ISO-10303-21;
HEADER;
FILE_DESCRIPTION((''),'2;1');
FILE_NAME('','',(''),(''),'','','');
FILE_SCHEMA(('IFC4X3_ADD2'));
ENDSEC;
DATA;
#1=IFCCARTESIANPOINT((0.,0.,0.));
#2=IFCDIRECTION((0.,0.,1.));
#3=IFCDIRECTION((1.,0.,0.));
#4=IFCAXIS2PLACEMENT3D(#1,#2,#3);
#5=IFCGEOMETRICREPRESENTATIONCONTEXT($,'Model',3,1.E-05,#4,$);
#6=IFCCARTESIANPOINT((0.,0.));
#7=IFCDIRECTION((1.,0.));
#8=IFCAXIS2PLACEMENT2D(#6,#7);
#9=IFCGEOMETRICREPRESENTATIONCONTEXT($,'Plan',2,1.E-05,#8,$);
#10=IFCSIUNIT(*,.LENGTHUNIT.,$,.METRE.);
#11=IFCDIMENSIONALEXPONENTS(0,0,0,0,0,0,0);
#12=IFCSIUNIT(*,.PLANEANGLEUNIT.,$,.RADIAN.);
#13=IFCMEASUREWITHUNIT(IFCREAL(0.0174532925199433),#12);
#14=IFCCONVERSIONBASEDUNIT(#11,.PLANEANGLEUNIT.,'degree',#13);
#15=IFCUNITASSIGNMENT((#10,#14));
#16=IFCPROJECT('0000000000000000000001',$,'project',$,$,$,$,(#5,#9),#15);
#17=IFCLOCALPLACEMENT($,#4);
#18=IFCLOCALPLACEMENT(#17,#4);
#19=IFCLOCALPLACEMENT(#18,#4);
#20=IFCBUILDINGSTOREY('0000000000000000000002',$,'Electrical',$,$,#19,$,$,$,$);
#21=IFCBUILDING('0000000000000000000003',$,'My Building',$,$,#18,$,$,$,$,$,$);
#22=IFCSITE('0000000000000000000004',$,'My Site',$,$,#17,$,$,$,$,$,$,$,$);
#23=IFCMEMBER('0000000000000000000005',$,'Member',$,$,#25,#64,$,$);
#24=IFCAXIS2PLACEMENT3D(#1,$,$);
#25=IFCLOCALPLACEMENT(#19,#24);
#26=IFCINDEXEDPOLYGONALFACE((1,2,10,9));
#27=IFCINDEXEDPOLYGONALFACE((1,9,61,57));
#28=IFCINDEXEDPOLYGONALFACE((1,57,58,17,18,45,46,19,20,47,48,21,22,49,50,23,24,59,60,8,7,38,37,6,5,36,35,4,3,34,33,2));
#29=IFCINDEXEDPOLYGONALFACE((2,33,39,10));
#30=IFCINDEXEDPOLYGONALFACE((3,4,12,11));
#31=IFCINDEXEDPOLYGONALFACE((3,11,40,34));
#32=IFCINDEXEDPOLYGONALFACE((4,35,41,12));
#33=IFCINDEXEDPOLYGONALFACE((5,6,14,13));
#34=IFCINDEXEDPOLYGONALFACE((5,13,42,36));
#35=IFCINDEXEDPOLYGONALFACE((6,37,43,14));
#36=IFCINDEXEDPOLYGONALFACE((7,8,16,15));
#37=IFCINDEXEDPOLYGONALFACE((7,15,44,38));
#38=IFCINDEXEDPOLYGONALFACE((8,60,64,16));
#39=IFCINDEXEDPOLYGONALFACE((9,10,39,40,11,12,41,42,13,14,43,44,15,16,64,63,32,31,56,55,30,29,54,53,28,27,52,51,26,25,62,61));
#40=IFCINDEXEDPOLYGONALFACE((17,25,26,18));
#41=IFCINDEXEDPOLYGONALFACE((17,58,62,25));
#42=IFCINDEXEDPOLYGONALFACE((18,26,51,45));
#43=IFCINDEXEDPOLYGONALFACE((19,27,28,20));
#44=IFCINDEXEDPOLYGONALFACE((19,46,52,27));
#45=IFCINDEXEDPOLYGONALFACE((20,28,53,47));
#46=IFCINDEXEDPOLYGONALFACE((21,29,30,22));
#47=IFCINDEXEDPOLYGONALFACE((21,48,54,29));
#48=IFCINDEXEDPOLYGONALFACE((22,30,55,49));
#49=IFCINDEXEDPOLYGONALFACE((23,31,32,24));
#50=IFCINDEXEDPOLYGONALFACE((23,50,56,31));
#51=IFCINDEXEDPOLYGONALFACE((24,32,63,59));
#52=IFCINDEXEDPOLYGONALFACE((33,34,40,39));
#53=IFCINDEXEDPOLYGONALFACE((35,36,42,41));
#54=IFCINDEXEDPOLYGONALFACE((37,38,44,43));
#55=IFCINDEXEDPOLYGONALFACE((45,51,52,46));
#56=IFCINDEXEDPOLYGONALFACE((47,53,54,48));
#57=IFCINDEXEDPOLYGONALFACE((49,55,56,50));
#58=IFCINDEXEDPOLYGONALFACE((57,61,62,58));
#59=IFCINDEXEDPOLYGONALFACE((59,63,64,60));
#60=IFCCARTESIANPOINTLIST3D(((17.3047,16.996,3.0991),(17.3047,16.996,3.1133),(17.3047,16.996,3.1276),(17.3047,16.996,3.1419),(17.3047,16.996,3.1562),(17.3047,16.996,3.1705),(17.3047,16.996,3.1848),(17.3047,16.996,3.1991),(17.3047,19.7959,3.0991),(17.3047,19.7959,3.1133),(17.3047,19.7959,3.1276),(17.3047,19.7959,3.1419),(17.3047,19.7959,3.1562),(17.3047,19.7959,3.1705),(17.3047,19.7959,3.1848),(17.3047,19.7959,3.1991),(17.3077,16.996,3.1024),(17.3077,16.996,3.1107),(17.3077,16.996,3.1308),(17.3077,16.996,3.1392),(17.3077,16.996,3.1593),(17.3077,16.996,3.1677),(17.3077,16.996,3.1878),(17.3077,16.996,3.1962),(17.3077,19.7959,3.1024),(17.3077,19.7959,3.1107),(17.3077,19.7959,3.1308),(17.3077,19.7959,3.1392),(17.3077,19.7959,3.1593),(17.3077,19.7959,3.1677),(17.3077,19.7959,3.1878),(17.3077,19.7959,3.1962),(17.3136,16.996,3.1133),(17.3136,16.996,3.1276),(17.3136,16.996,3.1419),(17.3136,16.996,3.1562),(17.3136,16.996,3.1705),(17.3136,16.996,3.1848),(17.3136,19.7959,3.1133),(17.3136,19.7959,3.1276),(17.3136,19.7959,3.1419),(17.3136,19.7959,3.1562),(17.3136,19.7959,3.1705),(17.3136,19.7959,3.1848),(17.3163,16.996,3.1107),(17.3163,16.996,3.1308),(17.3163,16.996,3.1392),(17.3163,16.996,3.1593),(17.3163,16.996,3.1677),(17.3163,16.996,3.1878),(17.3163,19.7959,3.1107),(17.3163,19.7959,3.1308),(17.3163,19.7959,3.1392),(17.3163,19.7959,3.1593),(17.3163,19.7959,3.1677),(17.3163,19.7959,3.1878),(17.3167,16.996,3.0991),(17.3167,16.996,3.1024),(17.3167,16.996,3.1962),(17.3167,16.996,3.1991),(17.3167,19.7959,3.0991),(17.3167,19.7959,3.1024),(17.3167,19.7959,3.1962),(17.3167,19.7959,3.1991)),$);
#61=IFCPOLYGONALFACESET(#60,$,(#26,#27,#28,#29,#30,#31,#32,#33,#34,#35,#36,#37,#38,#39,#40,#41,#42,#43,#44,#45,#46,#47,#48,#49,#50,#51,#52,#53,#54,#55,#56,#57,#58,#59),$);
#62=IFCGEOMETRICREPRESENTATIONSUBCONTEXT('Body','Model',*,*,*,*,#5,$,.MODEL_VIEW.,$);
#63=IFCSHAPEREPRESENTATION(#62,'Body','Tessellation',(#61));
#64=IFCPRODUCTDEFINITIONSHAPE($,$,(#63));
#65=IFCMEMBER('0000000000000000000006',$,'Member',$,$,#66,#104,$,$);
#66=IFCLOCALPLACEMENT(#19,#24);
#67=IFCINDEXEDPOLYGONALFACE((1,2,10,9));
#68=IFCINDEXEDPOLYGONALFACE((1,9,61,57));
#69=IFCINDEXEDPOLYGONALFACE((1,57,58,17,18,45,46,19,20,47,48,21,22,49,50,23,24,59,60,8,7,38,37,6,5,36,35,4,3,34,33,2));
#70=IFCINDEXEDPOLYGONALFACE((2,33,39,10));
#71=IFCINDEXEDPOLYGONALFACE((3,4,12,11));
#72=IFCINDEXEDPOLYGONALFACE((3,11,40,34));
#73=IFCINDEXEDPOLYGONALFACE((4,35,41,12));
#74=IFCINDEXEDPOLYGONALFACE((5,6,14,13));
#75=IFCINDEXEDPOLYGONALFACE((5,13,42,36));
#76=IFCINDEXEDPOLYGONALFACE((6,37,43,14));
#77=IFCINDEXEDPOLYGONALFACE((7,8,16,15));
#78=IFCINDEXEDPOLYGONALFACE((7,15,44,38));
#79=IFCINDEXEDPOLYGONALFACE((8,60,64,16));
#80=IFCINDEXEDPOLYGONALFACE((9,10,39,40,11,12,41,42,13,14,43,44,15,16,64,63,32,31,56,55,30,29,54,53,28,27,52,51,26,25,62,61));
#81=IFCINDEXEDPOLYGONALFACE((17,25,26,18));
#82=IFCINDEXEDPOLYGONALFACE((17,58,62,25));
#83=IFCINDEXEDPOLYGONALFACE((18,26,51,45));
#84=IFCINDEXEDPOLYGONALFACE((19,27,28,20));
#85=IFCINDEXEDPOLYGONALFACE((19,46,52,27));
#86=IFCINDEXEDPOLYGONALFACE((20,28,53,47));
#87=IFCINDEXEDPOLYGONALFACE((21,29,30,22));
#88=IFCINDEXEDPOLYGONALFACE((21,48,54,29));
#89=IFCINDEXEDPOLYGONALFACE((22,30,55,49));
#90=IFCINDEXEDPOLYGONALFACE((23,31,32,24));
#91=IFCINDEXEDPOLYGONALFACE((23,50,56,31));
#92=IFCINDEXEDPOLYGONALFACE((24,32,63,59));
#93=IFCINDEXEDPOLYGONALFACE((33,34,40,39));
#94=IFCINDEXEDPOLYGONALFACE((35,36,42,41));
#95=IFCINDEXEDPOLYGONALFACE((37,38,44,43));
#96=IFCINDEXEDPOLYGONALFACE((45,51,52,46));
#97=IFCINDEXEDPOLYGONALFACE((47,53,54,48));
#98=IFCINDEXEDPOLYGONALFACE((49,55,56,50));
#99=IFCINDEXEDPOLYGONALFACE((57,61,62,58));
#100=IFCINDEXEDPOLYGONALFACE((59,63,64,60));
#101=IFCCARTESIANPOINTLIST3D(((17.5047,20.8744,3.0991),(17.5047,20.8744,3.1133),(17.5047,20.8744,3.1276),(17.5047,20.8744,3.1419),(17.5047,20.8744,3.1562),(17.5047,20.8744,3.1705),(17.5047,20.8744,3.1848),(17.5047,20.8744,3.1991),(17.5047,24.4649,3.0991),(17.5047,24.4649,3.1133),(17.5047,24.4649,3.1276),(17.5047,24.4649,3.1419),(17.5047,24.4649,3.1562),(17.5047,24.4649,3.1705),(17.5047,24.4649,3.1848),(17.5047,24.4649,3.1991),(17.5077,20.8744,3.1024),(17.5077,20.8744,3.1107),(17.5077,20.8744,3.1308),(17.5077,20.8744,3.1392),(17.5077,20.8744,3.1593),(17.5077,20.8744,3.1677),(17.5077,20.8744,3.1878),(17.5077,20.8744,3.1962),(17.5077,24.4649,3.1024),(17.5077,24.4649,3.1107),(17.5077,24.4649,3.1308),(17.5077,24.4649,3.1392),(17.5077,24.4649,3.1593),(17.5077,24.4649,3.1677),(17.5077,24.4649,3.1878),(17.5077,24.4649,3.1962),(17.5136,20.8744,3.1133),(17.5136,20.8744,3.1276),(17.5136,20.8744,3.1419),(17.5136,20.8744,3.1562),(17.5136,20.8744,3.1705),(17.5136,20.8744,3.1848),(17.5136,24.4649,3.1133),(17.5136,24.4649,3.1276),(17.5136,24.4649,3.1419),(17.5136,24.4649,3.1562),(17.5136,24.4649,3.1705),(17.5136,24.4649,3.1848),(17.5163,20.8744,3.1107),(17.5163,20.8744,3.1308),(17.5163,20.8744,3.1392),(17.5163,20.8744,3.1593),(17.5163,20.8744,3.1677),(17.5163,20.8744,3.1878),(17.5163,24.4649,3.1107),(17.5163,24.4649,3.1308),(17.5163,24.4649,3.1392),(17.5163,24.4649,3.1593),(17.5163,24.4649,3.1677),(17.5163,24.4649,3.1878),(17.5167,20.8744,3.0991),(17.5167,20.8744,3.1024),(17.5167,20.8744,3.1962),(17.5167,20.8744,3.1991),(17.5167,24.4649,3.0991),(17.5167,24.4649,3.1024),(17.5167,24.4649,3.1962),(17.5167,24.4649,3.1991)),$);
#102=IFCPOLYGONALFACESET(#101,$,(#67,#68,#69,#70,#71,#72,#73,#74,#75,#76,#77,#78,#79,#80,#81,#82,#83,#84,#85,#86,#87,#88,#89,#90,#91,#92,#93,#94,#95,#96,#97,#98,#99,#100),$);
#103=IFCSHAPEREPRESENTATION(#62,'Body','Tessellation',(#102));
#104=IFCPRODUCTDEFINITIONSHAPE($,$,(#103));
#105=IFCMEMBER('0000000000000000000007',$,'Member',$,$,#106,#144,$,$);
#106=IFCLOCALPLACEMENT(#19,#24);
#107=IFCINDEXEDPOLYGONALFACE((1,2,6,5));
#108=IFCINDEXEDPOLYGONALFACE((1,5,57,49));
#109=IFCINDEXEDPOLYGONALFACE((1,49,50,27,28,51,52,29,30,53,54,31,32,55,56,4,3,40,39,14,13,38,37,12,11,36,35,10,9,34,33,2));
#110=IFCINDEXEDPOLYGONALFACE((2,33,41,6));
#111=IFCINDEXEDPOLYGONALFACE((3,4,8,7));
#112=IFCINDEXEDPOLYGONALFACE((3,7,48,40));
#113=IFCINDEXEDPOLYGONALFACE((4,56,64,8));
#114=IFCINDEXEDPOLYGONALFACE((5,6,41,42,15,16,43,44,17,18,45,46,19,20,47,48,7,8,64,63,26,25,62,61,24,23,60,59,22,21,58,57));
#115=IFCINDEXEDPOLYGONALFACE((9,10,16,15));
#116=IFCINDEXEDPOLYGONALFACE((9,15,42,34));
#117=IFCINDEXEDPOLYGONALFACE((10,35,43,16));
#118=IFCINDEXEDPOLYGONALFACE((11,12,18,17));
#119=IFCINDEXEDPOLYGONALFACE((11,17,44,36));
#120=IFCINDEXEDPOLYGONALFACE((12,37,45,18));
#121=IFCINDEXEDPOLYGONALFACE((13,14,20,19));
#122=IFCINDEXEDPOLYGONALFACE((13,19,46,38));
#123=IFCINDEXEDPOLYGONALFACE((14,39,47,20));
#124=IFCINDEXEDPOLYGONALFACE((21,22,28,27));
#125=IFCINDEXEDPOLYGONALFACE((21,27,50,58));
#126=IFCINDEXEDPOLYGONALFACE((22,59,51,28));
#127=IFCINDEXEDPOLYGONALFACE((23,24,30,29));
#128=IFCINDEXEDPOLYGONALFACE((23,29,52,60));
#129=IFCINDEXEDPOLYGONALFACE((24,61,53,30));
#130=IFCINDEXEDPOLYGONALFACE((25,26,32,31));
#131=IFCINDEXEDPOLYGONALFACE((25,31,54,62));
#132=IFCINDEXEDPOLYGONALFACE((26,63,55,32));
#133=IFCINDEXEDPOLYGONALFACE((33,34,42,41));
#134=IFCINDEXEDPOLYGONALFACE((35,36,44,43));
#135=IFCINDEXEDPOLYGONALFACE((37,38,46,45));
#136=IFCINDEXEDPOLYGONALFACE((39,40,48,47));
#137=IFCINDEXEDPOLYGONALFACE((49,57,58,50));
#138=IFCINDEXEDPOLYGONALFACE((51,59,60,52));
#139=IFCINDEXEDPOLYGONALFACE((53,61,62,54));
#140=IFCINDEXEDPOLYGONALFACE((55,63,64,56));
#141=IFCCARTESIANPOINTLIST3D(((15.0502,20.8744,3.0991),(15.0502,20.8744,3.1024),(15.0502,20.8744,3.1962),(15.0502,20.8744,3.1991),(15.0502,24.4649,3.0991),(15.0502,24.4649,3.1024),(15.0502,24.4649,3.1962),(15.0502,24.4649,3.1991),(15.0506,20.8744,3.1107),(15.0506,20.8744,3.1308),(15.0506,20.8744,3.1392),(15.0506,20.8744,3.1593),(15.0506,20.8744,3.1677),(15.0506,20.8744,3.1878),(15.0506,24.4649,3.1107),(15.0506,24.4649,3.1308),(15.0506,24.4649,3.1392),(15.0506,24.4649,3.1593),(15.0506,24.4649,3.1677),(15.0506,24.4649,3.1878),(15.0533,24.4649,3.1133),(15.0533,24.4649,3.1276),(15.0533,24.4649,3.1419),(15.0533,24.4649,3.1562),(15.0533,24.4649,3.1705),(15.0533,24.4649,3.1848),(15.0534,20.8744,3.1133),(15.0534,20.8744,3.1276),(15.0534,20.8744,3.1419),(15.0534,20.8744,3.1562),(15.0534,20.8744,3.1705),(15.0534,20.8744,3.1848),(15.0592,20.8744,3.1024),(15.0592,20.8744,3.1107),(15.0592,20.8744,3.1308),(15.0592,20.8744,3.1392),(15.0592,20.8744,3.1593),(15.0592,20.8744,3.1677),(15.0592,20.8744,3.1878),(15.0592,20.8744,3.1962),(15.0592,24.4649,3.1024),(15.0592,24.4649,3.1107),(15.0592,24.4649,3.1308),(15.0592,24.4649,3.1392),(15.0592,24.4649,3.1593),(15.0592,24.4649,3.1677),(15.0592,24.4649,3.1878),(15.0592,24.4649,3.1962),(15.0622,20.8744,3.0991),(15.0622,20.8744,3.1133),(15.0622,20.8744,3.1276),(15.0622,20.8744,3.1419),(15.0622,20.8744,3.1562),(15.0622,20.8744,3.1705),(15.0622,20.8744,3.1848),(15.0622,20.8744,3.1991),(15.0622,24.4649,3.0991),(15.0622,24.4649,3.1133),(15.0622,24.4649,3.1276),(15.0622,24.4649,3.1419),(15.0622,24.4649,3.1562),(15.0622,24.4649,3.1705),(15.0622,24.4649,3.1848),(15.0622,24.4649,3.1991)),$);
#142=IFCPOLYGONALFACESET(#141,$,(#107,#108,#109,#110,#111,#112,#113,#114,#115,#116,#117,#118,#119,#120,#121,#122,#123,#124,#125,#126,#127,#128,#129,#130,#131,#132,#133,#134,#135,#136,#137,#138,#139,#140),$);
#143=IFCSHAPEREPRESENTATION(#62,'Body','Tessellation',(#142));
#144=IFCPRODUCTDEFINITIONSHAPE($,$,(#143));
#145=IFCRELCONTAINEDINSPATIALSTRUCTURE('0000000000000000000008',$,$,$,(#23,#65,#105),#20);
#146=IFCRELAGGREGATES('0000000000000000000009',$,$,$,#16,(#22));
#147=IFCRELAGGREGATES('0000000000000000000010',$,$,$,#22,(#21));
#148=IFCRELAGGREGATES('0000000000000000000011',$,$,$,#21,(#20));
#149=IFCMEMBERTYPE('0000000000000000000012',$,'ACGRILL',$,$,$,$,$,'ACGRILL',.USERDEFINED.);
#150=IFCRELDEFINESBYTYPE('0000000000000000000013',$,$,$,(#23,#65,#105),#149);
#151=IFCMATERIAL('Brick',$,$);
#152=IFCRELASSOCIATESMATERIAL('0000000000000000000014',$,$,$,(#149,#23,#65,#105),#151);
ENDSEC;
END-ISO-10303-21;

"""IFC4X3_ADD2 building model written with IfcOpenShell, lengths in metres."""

from ifc_helpers import new_model, entity, si_unit, converted_unit, frame, origin_with_axes, origin_2d_with_axis, place, context, subcontext, project, spatial, indexed_curve, outline, extrude, material, material_profile, profile_set, profile_usage, type_object, element, save


model = new_model("IFC4X3_ADD2")

# Units and contexts
model_context = context("Model", 3, precision=1e-05, world=origin_with_axes())
plan_context = context("Plan", 2, precision=1e-05, world=origin_2d_with_axis())
body_context = subcontext(model_context, "Body", "Model", "MODEL_VIEW")
ifc_project = project(units=[si_unit("LENGTHUNIT", "METRE"), converted_unit("PLANEANGLEUNIT", "degree", entity("IfcReal", 0.0174532925199433), si_unit("PLANEANGLEUNIT", "RADIAN"), dimensions=[0, 0, 0, 0, 0, 0, 0])], contexts=[model_context, plan_context])

# Site, building, storey
site_placement = place(None, origin_with_axes())
site = spatial("IfcSite", under=ifc_project, at=site_placement, Name="My Site")
building_placement = place(site_placement, origin_with_axes())
building = spatial("IfcBuilding", under=site, at=building_placement, Name="My Building")
storey_placement = place(building_placement, origin_with_axes())
storey = spatial("IfcBuildingStorey", under=building, at=storey_placement, Name="Electrical")

# Members
ifc_material_1 = material(Name="Brick")
ifc_material_profile_1 = material_profile(ifc_material_1, outline(indexed_curve([(0.012, 0.0), (0.012, 0.0143), (0.0031, 0.0143), (0.0031, 0.0286), (0.012, 0.0286), (0.012, 0.0429), (0.0031, 0.0429), (0.0031, 0.0571), (0.012, 0.0571), (0.012, 0.0714), (0.0031, 0.0714), (0.0031, 0.0857), (0.012, 0.0857), (0.012, 0.1), (0.0, 0.1), (0.0, 0.0971), (0.009, 0.0971), (0.009, 0.0887), (0.0004, 0.0887), (0.0004, 0.0686), (0.009, 0.0686), (0.009, 0.0602), (0.0004, 0.0602), (0.0004, 0.0401), (0.009, 0.0401), (0.009, 0.0317), (0.0004, 0.0317), (0.0004, 0.0116), (0.009, 0.0116), (0.009, 0.0034), (0.0, 0.0034), (0.0, 0.0), (0.012, 0.0)])))
ifc_profile_set_1 = profile_set([ifc_material_profile_1])
ifc_profile_usage_1 = profile_usage(ifc_profile_set_1, cardinal=5)
member_type = type_object("IfcMemberType", Name="ACGRILL", ElementType="ACGRILL", PredefinedType="USERDEFINED", material=ifc_profile_set_1)
member_1_placement = place(storey_placement, frame((17.3167, 16.996, 3.0991), z_axis=(0.0, 1.0, 0.0), x_axis=(-1.0, 0.0, 0.0)))
element("IfcMember", 1, at=member_1_placement, inside=storey, type_object=member_type, material=ifc_profile_usage_1, Name="Member", context=body_context, shape_type="SweptSolid", body=[
    extrude(outline(indexed_curve([(0.012, 0.0), (0.012, 0.0143), (0.0031, 0.0143), (0.0031, 0.0286), (0.012, 0.0286), (0.012, 0.0429), (0.0031, 0.0429), (0.0031, 0.0571), (0.012, 0.0571), (0.012, 0.0714), (0.0031, 0.0714), (0.0031, 0.0857), (0.012, 0.0857), (0.012, 0.1), (0.0, 0.1), (0.0, 0.0971), (0.009, 0.0971), (0.009, 0.0887), (0.0004, 0.0887), (0.0004, 0.0686), (0.009, 0.0686), (0.009, 0.0602), (0.0004, 0.0602), (0.0004, 0.0401), (0.009, 0.0401), (0.009, 0.0317), (0.0004, 0.0317), (0.0004, 0.0116), (0.009, 0.0116), (0.009, 0.0034), (0.0, 0.0034), (0.0, 0.0), (0.012, 0.0)])), origin_with_axes(), (0.0, 0.0, 1.0), 2.7999),
])
ifc_profile_usage_2 = profile_usage(ifc_profile_set_1, cardinal=5)
member_2_placement = place(storey_placement, frame((17.5167, 20.8744, 3.0991), z_axis=(0.0, 1.0, 0.0), x_axis=(-1.0, 0.0, 0.0)))
element("IfcMember", 2, at=member_2_placement, inside=storey, type_object=member_type, material=ifc_profile_usage_2, Name="Member", context=body_context, shape_type="SweptSolid", body=[
    extrude(outline(indexed_curve([(0.012, 0.0), (0.012, 0.0143), (0.0031, 0.0143), (0.0031, 0.0286), (0.012, 0.0286), (0.012, 0.0429), (0.0031, 0.0429), (0.0031, 0.0571), (0.012, 0.0571), (0.012, 0.0714), (0.0031, 0.0714), (0.0031, 0.0857), (0.012, 0.0857), (0.012, 0.1), (0.0, 0.1), (0.0, 0.0971), (0.009, 0.0971), (0.009, 0.0887), (0.0004, 0.0887), (0.0004, 0.0686), (0.009, 0.0686), (0.009, 0.0602), (0.0004, 0.0602), (0.0004, 0.0401), (0.009, 0.0401), (0.009, 0.0317), (0.0004, 0.0317), (0.0004, 0.0116), (0.009, 0.0116), (0.009, 0.0034), (0.0, 0.0034), (0.0, 0.0), (0.012, 0.0)])), origin_with_axes(), (0.0, 0.0, 1.0), 3.5905),
])
ifc_profile_usage_3 = profile_usage(ifc_profile_set_1, cardinal=5)
member_3_placement = place(storey_placement, frame((15.0502, 24.4649, 3.0991), z_axis=(0.0, -1.0, 0.0), x_axis=(1.0, 0.0, 0.0)))
element("IfcMember", 3, at=member_3_placement, inside=storey, type_object=member_type, material=ifc_profile_usage_3, Name="Member", context=body_context, shape_type="SweptSolid", body=[
    extrude(outline(indexed_curve([(0.012, 0.0), (0.012, 0.0143), (0.0031, 0.0143), (0.0031, 0.0286), (0.012, 0.0286), (0.012, 0.0429), (0.0031, 0.0429), (0.0031, 0.0571), (0.012, 0.0571), (0.012, 0.0714), (0.0031, 0.0714), (0.0031, 0.0857), (0.012, 0.0857), (0.012, 0.1), (0.0, 0.1), (0.0, 0.0971), (0.009, 0.0971), (0.009, 0.0887), (0.0004, 0.0887), (0.0004, 0.0686), (0.009, 0.0686), (0.009, 0.0602), (0.0004, 0.0602), (0.0004, 0.0401), (0.009, 0.0401), (0.009, 0.0317), (0.0004, 0.0317), (0.0004, 0.0116), (0.009, 0.0116), (0.009, 0.0034), (0.0, 0.0034), (0.0, 0.0), (0.012, 0.0)])), origin_with_axes(), (0.0, 0.0, 1.0), 3.5905),
])

save(model, "model.ifc")
